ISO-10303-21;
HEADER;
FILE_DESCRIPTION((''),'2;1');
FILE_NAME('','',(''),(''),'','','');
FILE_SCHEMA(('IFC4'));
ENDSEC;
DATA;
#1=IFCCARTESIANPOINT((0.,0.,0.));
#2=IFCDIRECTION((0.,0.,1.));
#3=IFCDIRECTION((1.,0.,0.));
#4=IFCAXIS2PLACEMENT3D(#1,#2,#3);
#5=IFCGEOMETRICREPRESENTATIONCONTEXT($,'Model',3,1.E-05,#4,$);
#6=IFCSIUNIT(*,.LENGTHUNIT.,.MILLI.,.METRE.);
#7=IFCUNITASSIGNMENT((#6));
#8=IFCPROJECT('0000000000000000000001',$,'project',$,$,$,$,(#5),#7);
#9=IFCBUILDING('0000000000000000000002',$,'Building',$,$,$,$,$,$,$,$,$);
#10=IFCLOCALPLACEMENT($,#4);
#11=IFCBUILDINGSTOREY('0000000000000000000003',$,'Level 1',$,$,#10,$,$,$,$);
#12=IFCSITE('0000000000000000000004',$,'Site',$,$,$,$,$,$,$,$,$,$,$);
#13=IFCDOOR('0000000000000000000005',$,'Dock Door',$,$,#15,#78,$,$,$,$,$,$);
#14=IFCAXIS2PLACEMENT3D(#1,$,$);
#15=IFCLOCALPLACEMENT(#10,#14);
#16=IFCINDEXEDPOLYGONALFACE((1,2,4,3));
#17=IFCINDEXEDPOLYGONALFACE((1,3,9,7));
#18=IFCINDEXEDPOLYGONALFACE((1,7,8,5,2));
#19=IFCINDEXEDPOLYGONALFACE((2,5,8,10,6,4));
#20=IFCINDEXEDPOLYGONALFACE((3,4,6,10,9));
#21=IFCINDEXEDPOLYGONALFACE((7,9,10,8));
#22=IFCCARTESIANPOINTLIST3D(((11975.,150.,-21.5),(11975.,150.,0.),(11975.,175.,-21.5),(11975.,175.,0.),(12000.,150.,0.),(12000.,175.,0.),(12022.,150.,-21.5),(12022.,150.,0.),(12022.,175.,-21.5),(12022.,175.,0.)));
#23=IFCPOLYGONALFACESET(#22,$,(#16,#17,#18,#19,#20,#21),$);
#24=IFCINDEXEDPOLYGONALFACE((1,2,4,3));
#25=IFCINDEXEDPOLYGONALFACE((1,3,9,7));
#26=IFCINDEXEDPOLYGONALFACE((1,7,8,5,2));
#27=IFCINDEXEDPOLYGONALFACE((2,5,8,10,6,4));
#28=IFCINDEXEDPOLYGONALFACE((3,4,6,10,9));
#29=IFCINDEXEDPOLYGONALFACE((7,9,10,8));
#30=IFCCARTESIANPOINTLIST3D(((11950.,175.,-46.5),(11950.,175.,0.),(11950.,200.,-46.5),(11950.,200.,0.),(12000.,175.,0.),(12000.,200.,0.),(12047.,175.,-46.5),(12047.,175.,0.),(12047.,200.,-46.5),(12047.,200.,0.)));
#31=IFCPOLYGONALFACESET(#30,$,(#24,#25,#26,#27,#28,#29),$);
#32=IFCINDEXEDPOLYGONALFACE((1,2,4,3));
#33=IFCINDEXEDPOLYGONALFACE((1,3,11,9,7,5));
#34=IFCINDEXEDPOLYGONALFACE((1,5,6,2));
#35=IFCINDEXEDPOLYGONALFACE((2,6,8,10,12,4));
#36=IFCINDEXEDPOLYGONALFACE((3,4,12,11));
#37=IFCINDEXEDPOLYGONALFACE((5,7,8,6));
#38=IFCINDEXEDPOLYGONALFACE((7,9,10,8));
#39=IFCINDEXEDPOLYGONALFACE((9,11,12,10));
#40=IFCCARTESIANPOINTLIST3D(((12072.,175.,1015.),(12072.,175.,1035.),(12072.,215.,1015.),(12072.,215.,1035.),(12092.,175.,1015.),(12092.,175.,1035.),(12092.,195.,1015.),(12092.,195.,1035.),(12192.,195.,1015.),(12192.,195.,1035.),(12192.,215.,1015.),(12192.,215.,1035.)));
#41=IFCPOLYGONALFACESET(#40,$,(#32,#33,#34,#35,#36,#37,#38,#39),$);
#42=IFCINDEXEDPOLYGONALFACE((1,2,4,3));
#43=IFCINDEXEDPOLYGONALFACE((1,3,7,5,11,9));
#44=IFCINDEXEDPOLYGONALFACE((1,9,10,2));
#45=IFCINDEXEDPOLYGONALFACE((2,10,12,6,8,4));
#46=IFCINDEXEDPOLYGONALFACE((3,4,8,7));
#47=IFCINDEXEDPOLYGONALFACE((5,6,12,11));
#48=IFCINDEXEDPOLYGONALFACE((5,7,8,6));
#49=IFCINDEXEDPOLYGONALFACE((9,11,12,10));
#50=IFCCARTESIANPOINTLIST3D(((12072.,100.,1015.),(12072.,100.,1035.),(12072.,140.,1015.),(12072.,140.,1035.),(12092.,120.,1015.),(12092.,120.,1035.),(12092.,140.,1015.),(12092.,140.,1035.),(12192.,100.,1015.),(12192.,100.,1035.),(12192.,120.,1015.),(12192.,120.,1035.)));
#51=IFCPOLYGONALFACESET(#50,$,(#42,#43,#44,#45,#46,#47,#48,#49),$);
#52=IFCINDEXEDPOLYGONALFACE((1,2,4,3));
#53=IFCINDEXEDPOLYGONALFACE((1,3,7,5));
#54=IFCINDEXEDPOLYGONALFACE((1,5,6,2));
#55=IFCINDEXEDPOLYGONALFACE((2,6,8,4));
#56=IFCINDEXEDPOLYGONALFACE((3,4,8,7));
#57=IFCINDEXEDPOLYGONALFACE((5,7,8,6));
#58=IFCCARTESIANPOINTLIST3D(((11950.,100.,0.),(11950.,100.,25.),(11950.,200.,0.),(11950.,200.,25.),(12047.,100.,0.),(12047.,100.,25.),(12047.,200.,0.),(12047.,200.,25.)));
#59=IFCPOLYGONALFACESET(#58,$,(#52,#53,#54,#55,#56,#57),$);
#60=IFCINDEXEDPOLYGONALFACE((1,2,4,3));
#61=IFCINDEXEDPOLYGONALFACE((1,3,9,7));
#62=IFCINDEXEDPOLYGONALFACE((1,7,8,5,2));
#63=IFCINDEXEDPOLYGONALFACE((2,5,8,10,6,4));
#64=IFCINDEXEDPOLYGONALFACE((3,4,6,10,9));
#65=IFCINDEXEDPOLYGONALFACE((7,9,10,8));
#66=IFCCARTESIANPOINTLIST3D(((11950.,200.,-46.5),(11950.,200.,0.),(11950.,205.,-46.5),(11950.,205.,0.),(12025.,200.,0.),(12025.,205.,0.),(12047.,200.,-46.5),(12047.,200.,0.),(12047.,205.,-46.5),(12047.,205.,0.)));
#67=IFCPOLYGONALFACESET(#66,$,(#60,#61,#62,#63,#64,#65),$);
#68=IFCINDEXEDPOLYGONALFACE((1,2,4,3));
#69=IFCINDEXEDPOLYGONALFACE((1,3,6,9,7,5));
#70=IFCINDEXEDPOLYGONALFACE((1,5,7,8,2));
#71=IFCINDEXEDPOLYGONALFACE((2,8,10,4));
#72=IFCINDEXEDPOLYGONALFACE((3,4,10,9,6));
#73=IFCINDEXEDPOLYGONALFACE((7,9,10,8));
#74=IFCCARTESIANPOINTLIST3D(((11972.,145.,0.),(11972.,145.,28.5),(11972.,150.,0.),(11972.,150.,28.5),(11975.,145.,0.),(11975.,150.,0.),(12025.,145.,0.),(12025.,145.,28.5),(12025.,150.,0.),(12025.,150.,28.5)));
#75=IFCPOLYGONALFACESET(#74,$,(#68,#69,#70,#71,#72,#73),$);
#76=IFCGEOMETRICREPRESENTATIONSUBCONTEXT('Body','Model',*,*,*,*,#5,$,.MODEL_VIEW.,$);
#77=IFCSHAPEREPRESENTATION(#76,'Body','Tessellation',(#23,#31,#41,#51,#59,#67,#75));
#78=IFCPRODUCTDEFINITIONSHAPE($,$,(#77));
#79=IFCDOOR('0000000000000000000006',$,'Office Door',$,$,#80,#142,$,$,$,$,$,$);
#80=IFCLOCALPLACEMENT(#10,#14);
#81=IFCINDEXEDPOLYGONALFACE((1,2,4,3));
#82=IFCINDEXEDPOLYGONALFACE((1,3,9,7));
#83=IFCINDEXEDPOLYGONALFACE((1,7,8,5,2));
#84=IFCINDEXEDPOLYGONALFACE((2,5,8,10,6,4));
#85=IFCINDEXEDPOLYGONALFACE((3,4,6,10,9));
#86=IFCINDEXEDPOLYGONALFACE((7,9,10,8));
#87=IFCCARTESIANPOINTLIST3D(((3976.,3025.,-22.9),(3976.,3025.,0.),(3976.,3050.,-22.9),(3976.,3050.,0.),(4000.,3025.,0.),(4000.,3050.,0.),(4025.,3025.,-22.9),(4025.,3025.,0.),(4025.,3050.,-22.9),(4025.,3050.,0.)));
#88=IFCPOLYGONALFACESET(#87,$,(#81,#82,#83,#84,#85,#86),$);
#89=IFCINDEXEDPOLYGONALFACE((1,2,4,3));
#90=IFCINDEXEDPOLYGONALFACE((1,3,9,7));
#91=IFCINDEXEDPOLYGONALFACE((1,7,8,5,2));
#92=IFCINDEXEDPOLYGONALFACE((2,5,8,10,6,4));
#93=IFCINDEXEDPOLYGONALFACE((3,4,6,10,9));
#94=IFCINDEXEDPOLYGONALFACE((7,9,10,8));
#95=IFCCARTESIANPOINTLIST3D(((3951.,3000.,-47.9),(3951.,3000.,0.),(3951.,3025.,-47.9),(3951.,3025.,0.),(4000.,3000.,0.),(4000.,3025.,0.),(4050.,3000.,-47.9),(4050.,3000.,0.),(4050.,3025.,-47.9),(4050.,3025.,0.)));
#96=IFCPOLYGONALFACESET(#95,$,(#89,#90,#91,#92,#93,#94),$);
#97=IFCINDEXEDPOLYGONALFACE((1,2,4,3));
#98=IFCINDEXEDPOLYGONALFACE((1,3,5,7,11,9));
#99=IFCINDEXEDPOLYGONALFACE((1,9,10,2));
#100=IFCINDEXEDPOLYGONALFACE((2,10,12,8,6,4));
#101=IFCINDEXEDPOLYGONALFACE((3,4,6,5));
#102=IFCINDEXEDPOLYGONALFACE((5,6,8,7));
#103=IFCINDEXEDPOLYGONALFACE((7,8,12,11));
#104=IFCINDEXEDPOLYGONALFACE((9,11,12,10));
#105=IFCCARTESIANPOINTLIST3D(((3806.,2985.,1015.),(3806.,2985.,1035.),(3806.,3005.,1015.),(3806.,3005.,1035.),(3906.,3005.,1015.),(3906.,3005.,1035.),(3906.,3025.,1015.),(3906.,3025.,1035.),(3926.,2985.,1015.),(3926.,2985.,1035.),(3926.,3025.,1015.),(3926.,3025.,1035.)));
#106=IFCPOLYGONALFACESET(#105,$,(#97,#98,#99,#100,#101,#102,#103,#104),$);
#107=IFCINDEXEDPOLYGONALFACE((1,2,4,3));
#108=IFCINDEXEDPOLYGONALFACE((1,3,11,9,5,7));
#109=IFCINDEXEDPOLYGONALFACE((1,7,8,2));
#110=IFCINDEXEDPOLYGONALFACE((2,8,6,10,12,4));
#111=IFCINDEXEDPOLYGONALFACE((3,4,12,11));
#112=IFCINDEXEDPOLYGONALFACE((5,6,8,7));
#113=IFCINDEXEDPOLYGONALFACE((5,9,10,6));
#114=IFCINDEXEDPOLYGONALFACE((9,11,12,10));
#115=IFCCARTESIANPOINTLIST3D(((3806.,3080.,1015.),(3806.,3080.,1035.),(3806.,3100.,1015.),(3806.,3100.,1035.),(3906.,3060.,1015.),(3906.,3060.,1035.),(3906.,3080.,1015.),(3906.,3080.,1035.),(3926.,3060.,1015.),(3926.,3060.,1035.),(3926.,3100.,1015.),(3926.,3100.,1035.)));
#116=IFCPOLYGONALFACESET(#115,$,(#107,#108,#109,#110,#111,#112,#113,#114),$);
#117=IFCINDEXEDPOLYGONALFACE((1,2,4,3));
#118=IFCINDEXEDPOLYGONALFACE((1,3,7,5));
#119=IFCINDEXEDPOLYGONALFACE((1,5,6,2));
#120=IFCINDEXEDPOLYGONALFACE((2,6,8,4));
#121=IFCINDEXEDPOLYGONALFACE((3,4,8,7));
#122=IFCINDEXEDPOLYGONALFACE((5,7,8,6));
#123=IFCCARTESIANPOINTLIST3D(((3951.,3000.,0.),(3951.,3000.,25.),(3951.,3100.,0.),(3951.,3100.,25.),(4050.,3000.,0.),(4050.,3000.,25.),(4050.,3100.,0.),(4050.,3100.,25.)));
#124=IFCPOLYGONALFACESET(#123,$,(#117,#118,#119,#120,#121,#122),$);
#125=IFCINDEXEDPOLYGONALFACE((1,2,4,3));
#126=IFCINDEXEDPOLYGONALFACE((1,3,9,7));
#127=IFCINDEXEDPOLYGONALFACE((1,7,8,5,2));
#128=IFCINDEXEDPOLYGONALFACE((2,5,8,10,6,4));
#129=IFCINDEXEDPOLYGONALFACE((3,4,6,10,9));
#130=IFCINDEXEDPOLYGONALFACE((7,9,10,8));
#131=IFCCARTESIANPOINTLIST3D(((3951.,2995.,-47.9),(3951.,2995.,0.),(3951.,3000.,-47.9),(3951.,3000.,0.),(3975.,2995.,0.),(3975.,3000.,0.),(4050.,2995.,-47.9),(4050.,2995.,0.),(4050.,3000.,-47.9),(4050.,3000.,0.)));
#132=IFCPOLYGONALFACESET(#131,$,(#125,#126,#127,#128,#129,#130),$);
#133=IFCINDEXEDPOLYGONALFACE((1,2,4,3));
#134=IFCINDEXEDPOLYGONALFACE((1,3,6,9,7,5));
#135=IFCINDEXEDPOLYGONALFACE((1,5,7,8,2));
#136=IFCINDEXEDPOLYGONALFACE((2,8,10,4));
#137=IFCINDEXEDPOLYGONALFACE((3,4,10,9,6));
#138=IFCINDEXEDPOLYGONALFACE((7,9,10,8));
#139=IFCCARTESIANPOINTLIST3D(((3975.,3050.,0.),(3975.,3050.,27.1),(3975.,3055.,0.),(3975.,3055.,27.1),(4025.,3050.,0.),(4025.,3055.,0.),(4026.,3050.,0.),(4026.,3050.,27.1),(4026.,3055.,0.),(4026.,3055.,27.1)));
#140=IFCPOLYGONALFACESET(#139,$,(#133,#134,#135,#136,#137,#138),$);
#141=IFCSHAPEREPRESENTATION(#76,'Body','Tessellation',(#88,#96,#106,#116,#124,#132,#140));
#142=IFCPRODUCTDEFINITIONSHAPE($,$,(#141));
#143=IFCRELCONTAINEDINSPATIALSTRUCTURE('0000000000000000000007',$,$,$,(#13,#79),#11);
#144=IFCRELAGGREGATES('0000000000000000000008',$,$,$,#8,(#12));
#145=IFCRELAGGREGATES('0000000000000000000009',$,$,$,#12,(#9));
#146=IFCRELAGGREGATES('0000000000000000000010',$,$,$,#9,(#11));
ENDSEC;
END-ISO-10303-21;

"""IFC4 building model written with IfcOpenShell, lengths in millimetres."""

from ifc_helpers import new_model, si_unit, frame, origin_with_axes, place, context, subcontext, project, spatial, line, indexed_curve, outline, extrude, element, save


model = new_model("IFC4")

# Units and contexts
model_context = context("Model", 3, precision=1e-05, world=origin_with_axes())
body_context = subcontext(model_context, "Body", "Model", "MODEL_VIEW")
ifc_project = project(units=[si_unit("LENGTHUNIT", "METRE", prefix="MILLI")], contexts=[model_context])

# Site, building, storey
site = spatial("IfcSite", under=ifc_project, Name="Site")
building = spatial("IfcBuilding", under=site, Name="Building")
storey_placement = place(None, origin_with_axes())
storey = spatial("IfcBuildingStorey", under=building, at=storey_placement, Name="Level 1")

# Doors
door_1_placement = place(storey_placement, frame((12000.0, 200.0, 0.0), z_axis=(0.0, 0.0, 1.0), x_axis=(-1.0, 0.0, 0.0)))
element("IfcDoor", 1, at=door_1_placement, inside=storey, Name="Dock Door", context=body_context, shape_type="SweptSolid", body=[
    extrude(outline(indexed_curve([(0.0, 0.0), (0.0, 3.5), (3.0, 3.5), (3.0, 0.0), (-22.0, 0.0), (-22.0, -21.5), (25.0, -21.5), (25.0, 0.0)], segments=[line(1, 2, 3, 4, 5, 6, 7, 8, 1)])), frame((0.0, 25.0, 0.0), z_axis=(0.0, -1.0, 0.0), x_axis=(1.0, 0.0, 0.0)), (0.0, 0.0, -1.0), 25.0),
    extrude(outline(indexed_curve([(0.0, 0.0), (0.0, 3.5), (3.0, 3.5), (3.0, 0.0), (-47.0, 0.0), (-47.0, -46.5), (50.0, -46.5), (50.0, 0.0)], segments=[line(1, 2, 3, 4, 5, 6, 7, 8, 1)])), frame((0.0, 0.0, 0.0), z_axis=(0.0, -1.0, 0.0), x_axis=(1.0, 0.0, 0.0)), (0.0, 0.0, -1.0), 25.0),
    extrude(outline(indexed_curve([(0.0, 0.0), (-47.0, 0.0), (-47.0, 35.0), (0.0, 35.0)], segments=[line(1, 2, 3, 4, 1)])), frame((25.0, 25.0, 25.0), z_axis=(0.0, 0.0, 1.0), x_axis=(1.0, 0.0, 0.0)), (0.0, 0.0, 1.0), -46.5),
    extrude(outline(indexed_curve([(0.0, 0.0), (0.0, -40.0), (-120.0, -40.0), (-120.0, -20.0), (-20.0, -20.0), (-20.0, 0.0)], segments=[line(1, 2, 3, 4, 5, 6, 1)])), frame((-72.0, 25.0, 1015.0), z_axis=(0.0, 0.0, 1.0), x_axis=(1.0, 0.0, 0.0)), (0.0, 0.0, 1.0), 20.0),
    extrude(outline(indexed_curve([(0.0, 0.0), (0.0, 40.0), (-120.0, 40.0), (-120.0, 20.0), (-20.0, 20.0), (-20.0, 0.0)], segments=[line(1, 2, 3, 4, 5, 6, 1)])), frame((-72.0, 60.0, 1015.0), z_axis=(0.0, 0.0, 1.0), x_axis=(1.0, 0.0, 0.0)), (0.0, 0.0, 1.0), 20.0),
    extrude(outline(indexed_curve([(0.0, 0.0), (-97.0, 0.0), (-97.0, 100.0), (0.0, 100.0)], segments=[line(1, 2, 3, 4, 1)])), frame((50.0, 0.0, 0.0), z_axis=(0.0, 0.0, 1.0), x_axis=(1.0, 0.0, 0.0)), (0.0, 0.0, 1.0), 25.0),
    extrude(outline(indexed_curve([(0.0, 0.0), (0.0, 28.5), (53.0, 28.5), (53.0, 0.0), (-22.0, 0.0), (-22.0, -46.5), (75.0, -46.5), (75.0, 0.0)], segments=[line(1, 2, 3, 4, 5, 6, 7, 8, 1)])), frame((-25.0, -5.0, 0.0), z_axis=(0.0, -1.0, 0.0), x_axis=(1.0, 0.0, 0.0)), (0.0, 0.0, -1.0), 5.0),
    extrude(outline(indexed_curve([(0.0, 0.0), (0.0, 28.5), (53.0, 28.5), (53.0, 0.0), (3.0, 0.0), (3.0, -21.5), (50.0, -21.5), (50.0, 0.0)], segments=[line(1, 2, 3, 4, 5, 6, 7, 8, 1)])), frame((-25.0, 50.0, 0.0), z_axis=(0.0, -1.0, 0.0), x_axis=(1.0, 0.0, 0.0)), (0.0, 0.0, -1.0), 5.0),
])
door_2_placement = place(storey_placement, frame((4000.0, 3000.0, 0.0), z_axis=(0.0, 0.0, 1.0), x_axis=(1.0, 0.0, 0.0)))
element("IfcDoor", 2, at=door_2_placement, inside=storey, Name="Office Door", context=body_context, shape_type="SweptSolid", body=[
    extrude(outline(indexed_curve([(0.0, 0.0), (0.0, 2.1), (1.0, 2.1), (1.0, 0.0), (-24.0, 0.0), (-24.0, -22.9), (25.0, -22.9), (25.0, 0.0)], segments=[line(1, 2, 3, 4, 5, 6, 7, 8, 1)])), frame((0.0, 25.0, 0.0), z_axis=(0.0, -1.0, 0.0), x_axis=(1.0, 0.0, 0.0)), (0.0, 0.0, -1.0), 25.0),
    extrude(outline(indexed_curve([(0.0, 0.0), (0.0, 2.1), (1.0, 2.1), (1.0, 0.0), (-49.0, 0.0), (-49.0, -47.9), (50.0, -47.9), (50.0, 0.0)], segments=[line(1, 2, 3, 4, 5, 6, 7, 8, 1)])), frame((0.0, 0.0, 0.0), z_axis=(0.0, -1.0, 0.0), x_axis=(1.0, 0.0, 0.0)), (0.0, 0.0, -1.0), 25.0),
    extrude(outline(indexed_curve([(0.0, 0.0), (-49.0, 0.0), (-49.0, 35.0), (0.0, 35.0)], segments=[line(1, 2, 3, 4, 1)])), frame((25.0, 25.0, 25.0), z_axis=(0.0, 0.0, 1.0), x_axis=(1.0, 0.0, 0.0)), (0.0, 0.0, 1.0), -47.9),
    extrude(outline(indexed_curve([(0.0, 0.0), (0.0, -40.0), (-120.0, -40.0), (-120.0, -20.0), (-20.0, -20.0), (-20.0, 0.0)], segments=[line(1, 2, 3, 4, 5, 6, 1)])), frame((-74.0, 25.0, 1015.0), z_axis=(0.0, 0.0, 1.0), x_axis=(1.0, 0.0, 0.0)), (0.0, 0.0, 1.0), 20.0),
    extrude(outline(indexed_curve([(0.0, 0.0), (0.0, 40.0), (-120.0, 40.0), (-120.0, 20.0), (-20.0, 20.0), (-20.0, 0.0)], segments=[line(1, 2, 3, 4, 5, 6, 1)])), frame((-74.0, 60.0, 1015.0), z_axis=(0.0, 0.0, 1.0), x_axis=(1.0, 0.0, 0.0)), (0.0, 0.0, 1.0), 20.0),
    extrude(outline(indexed_curve([(0.0, 0.0), (-99.0, 0.0), (-99.0, 100.0), (0.0, 100.0)], segments=[line(1, 2, 3, 4, 1)])), frame((50.0, 0.0, 0.0), z_axis=(0.0, 0.0, 1.0), x_axis=(1.0, 0.0, 0.0)), (0.0, 0.0, 1.0), 25.0),
    extrude(outline(indexed_curve([(0.0, 0.0), (0.0, 27.1), (51.0, 27.1), (51.0, 0.0), (-24.0, 0.0), (-24.0, -47.9), (75.0, -47.9), (75.0, 0.0)], segments=[line(1, 2, 3, 4, 5, 6, 7, 8, 1)])), frame((-25.0, -5.0, 0.0), z_axis=(0.0, -1.0, 0.0), x_axis=(1.0, 0.0, 0.0)), (0.0, 0.0, -1.0), 5.0),
    extrude(outline(indexed_curve([(0.0, 0.0), (0.0, 27.1), (51.0, 27.1), (51.0, 0.0), (1.0, 0.0), (1.0, -22.9), (50.0, -22.9), (50.0, 0.0)], segments=[line(1, 2, 3, 4, 5, 6, 7, 8, 1)])), frame((-25.0, 50.0, 0.0), z_axis=(0.0, -1.0, 0.0), x_axis=(1.0, 0.0, 0.0)), (0.0, 0.0, -1.0), 5.0),
])

save(model, "model.ifc")
